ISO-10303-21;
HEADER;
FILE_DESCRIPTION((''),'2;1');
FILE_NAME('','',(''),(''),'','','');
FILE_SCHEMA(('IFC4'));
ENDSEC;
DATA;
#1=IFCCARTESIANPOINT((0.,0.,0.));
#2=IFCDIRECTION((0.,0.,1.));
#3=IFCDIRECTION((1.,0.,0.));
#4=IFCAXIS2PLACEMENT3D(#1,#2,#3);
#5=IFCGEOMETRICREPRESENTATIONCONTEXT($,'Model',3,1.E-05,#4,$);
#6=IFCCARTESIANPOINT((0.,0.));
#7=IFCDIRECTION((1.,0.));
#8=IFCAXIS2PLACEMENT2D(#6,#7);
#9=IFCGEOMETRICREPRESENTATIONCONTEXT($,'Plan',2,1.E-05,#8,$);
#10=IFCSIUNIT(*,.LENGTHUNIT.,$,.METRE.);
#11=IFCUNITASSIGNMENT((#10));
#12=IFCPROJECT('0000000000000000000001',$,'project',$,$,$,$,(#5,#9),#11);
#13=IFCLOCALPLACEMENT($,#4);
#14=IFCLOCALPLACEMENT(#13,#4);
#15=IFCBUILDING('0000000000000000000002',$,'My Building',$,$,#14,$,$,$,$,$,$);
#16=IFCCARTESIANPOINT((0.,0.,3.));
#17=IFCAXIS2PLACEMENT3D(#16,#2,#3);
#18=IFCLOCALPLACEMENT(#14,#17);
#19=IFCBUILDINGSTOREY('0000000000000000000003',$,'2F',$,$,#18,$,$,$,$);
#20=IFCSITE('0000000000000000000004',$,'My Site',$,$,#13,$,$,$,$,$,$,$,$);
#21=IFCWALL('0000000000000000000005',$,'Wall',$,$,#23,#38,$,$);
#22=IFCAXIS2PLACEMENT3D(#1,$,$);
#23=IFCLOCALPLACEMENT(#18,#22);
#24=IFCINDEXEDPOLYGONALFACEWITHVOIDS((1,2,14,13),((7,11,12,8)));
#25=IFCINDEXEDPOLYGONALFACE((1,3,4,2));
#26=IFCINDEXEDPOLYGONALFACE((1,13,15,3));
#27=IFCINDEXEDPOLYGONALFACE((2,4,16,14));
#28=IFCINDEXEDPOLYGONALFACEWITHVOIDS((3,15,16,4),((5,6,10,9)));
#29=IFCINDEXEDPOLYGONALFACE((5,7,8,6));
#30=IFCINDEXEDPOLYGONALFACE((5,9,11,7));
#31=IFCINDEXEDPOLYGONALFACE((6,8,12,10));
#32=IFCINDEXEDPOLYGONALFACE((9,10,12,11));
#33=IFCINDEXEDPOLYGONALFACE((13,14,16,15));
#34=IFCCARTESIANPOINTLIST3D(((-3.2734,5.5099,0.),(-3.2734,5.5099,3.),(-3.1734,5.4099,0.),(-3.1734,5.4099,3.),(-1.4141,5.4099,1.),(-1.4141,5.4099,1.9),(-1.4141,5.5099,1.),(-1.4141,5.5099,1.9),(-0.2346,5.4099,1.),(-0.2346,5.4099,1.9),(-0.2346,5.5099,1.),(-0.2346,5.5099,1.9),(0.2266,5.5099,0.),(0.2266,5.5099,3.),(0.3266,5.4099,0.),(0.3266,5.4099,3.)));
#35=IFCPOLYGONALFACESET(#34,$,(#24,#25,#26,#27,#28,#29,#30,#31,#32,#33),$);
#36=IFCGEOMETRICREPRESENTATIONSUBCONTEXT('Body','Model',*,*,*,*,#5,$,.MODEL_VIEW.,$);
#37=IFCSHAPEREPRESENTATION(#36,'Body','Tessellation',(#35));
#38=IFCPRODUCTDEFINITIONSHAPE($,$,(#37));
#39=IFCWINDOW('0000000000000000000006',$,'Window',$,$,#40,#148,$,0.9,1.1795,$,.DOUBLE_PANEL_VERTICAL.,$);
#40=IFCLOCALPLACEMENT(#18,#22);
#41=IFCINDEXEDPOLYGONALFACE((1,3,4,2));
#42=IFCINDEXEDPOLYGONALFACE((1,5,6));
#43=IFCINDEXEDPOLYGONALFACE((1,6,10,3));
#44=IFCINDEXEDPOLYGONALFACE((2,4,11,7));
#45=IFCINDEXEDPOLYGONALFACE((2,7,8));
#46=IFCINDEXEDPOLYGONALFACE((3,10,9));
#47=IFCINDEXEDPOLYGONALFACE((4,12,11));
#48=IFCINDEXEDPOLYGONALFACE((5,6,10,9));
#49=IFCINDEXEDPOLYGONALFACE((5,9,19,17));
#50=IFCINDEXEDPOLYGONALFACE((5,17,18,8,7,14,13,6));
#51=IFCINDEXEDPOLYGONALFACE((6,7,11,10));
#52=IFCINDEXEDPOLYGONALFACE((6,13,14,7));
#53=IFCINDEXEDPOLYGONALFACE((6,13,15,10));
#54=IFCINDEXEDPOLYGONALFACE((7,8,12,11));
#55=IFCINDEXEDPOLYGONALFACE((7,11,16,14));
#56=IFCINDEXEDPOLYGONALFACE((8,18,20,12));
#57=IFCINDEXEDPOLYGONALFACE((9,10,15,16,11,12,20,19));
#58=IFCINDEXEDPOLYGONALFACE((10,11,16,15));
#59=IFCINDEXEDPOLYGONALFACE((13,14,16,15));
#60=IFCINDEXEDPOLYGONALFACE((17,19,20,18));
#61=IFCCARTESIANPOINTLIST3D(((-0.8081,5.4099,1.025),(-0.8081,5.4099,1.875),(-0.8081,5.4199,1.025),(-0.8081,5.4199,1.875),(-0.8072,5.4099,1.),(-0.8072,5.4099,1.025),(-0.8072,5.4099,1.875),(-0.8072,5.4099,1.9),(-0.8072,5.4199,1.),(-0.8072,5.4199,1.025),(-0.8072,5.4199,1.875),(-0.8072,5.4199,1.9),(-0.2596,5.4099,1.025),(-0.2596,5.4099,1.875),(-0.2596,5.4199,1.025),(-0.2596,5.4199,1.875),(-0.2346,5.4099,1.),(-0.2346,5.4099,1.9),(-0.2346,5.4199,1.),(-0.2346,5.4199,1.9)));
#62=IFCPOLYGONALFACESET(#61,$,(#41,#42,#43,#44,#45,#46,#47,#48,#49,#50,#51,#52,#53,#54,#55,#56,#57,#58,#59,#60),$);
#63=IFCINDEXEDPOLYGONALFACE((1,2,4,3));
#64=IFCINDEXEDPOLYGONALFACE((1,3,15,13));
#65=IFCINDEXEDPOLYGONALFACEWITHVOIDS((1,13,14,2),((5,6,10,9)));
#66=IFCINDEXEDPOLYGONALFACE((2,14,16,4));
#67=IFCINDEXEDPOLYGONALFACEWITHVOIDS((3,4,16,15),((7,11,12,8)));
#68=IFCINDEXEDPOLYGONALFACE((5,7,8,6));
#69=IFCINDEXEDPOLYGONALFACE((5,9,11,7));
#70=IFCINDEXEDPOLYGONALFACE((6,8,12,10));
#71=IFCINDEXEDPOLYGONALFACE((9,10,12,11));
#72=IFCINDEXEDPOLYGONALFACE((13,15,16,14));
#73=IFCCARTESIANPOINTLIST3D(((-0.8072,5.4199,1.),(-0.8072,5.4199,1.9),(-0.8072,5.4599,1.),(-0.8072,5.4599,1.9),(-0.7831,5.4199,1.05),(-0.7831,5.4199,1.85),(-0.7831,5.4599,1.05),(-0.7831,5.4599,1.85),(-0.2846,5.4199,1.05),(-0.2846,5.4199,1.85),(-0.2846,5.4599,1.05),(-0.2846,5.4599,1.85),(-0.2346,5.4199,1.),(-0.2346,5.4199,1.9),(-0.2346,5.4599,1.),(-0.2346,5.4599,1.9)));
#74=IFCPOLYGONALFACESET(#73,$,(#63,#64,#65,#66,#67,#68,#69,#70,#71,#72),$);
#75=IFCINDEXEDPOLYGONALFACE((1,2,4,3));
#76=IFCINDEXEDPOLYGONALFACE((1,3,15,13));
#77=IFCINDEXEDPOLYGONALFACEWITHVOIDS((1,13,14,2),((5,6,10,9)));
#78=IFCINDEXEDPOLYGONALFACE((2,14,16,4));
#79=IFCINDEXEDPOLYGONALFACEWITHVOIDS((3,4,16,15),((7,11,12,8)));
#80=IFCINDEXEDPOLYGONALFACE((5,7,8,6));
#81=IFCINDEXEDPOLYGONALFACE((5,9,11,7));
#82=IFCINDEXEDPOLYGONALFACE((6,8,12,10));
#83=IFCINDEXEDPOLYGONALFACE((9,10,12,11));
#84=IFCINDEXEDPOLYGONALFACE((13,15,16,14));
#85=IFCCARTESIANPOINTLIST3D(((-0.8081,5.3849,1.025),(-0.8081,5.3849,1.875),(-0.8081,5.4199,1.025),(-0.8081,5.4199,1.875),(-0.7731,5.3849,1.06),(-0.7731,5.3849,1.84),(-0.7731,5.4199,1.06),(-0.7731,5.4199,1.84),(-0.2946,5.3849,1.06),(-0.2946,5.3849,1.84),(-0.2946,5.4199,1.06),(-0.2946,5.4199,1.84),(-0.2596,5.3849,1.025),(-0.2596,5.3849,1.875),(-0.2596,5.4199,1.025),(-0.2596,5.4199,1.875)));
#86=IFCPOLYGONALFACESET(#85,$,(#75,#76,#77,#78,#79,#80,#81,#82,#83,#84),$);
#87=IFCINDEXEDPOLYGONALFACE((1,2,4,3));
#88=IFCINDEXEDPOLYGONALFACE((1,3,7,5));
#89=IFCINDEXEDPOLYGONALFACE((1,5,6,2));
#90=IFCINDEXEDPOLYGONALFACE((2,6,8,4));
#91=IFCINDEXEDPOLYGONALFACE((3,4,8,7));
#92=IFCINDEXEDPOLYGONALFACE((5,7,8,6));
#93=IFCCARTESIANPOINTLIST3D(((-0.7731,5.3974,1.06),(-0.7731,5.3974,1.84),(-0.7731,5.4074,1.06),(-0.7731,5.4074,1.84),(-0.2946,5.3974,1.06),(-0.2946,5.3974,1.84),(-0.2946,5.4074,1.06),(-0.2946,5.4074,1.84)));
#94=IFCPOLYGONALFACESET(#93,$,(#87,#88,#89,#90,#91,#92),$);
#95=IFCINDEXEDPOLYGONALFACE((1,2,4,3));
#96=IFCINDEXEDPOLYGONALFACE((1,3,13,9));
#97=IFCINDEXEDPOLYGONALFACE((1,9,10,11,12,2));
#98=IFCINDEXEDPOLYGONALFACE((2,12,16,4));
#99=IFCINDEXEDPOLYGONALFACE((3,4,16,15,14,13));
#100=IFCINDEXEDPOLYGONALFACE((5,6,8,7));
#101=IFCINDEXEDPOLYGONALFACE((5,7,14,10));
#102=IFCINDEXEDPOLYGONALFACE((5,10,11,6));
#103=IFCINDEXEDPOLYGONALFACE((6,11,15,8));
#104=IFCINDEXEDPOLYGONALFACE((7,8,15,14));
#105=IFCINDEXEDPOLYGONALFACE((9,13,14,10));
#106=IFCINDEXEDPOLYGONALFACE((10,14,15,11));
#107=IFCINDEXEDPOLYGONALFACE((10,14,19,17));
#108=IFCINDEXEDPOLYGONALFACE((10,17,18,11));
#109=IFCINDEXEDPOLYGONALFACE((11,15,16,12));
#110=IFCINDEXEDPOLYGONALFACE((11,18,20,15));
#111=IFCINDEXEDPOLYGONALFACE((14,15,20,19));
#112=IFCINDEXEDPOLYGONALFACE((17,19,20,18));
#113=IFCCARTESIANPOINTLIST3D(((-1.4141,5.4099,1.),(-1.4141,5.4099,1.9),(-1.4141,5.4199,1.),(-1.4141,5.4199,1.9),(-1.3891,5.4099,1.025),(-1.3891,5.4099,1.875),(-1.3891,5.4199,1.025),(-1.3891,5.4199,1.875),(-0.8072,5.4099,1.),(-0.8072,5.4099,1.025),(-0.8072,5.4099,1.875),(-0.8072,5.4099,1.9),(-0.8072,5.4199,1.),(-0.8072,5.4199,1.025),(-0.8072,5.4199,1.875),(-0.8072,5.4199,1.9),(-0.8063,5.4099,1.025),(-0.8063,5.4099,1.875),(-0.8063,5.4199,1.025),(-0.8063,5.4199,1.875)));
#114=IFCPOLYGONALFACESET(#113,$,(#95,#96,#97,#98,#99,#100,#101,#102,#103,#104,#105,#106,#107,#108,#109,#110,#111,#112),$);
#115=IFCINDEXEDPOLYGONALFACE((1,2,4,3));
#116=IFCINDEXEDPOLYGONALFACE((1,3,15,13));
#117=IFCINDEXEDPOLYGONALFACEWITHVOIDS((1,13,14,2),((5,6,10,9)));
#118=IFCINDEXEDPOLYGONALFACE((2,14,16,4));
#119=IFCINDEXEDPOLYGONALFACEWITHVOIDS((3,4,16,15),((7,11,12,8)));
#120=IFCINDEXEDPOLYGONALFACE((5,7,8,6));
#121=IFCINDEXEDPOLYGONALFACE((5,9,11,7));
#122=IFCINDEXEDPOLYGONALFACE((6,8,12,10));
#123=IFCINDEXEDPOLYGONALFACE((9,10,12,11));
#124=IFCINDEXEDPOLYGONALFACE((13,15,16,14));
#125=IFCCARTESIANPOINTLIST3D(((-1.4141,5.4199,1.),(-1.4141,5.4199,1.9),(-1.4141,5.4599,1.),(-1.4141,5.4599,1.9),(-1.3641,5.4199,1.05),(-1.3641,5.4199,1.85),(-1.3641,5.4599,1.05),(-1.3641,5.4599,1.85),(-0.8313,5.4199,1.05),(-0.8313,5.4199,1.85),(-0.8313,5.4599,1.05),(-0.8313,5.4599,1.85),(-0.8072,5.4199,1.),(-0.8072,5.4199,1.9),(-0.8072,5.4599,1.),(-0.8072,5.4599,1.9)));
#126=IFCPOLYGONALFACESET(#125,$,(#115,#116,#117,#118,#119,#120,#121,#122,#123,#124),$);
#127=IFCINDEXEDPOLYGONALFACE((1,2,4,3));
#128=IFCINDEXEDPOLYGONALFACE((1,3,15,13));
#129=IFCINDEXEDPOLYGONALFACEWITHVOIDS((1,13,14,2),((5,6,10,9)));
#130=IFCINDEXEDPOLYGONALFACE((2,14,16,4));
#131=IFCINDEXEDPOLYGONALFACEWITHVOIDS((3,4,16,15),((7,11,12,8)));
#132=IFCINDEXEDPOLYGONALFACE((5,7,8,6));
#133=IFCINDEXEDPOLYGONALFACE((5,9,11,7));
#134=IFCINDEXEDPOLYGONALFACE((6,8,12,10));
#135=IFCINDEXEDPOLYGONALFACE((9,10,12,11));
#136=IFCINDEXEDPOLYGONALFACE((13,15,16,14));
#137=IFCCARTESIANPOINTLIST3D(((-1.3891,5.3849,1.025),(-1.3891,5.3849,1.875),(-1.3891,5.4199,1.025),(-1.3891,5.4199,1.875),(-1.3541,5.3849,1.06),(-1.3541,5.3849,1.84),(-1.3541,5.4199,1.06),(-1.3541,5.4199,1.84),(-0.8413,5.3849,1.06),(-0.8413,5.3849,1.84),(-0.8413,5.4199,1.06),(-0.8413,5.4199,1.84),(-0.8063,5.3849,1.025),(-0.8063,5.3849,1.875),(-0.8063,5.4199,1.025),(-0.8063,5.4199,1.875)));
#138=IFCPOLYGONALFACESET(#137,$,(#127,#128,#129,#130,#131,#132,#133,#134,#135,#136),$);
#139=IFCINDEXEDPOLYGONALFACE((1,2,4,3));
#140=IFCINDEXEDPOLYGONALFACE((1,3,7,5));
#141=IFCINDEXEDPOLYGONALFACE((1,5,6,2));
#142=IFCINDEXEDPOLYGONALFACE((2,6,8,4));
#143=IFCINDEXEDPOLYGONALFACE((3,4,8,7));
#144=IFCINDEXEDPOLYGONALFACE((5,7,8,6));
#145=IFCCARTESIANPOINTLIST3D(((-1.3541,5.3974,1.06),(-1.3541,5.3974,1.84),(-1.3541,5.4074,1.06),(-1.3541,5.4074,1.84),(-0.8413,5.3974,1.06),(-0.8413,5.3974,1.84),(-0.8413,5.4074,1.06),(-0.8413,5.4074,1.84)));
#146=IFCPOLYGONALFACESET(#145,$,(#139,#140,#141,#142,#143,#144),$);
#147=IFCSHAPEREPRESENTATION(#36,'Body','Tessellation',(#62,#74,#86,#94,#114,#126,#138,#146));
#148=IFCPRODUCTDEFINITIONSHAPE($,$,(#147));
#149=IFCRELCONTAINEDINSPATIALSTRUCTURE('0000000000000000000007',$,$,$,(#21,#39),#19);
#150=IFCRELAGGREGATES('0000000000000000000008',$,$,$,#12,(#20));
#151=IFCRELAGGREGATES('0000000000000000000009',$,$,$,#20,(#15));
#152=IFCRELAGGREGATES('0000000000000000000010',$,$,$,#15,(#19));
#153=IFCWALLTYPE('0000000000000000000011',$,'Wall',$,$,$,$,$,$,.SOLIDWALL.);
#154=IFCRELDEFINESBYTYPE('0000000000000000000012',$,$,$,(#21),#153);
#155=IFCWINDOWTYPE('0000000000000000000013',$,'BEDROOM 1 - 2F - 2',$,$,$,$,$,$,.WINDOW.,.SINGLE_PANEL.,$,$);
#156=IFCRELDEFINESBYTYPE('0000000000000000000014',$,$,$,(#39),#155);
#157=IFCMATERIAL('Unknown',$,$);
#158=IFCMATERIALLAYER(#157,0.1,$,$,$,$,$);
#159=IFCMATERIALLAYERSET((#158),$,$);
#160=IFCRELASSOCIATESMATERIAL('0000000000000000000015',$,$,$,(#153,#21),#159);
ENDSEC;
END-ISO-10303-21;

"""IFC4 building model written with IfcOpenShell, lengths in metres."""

from ifc_helpers import new_model, entity, si_unit, frame, origin_with_axes, origin_2d_with_axis, place, context, subcontext, project, spatial, line, indexed_curve, outline, extrude, shape, source, transform, mapped, material, layer, layer_set, layer_usage, type_object, type_shapes, element, fill, save


model = new_model("IFC4")

# Units and contexts
model_context = context("Model", 3, precision=1e-05, world=origin_with_axes())
plan_context = context("Plan", 2, precision=1e-05, world=origin_2d_with_axis())
body_context_1 = subcontext(model_context, "Body", "Model", "MODEL_VIEW")
body_context_2 = subcontext(plan_context, "Body", "Plan", "PLAN_VIEW")
ifc_project = project(units=[si_unit("LENGTHUNIT", "METRE")], contexts=[model_context, plan_context])

# Site, building, storey
site_placement = place(None, origin_with_axes())
site = spatial("IfcSite", under=ifc_project, at=site_placement, Name="My Site")
building_placement = place(site_placement, origin_with_axes())
building = spatial("IfcBuilding", under=site, at=building_placement, Name="My Building")
storey_placement = place(building_placement, frame((0.0, 0.0, 3.0), z_axis=(0.0, 0.0, 1.0), x_axis=(1.0, 0.0, 0.0)))
storey = spatial("IfcBuildingStorey", under=building, at=storey_placement, Name="2F")

# Shared definitions
ifc_material = material(Name="Unknown")

# Shared definitions
ifc_layer_1 = layer(ifc_material, 0.1)
ifc_layer_set_1 = layer_set([ifc_layer_1])
wall_type = type_object("IfcWallType", Name="Wall", PredefinedType="SOLIDWALL", material=ifc_layer_set_1)

# Wall, opening, window
ifc_layer_usage_1 = layer_usage(ifc_layer_set_1, "AXIS2", "POSITIVE", 0.0)
wall_1_placement = place(storey_placement, frame((0.2266, 5.5099, 0.0), z_axis=(0.0, 0.0, 1.0), x_axis=(-1.0, 0.0, 0.0)))
wall_1 = element("IfcWall", 1, at=wall_1_placement, inside=storey, type_object=wall_type, material=ifc_layer_usage_1, Name="Wall", context=body_context_1, shape_type="SweptSolid", body=[
    extrude(outline(indexed_curve([(0.0, 0.0), (-0.1, 0.1), (3.4, 0.1), (3.5, 0.0)], segments=[line(1, 2, 3, 4, 1)])), origin_with_axes(), (0.0, 0.0, 1.0), 3.0),
])
shared_shape_1 = source(origin_with_axes(), body_context_1, "Body", "SweptSolid", [
    extrude(outline(indexed_curve([(0.0, 0.0), (1.1795, 0.0), (1.1795, 0.9), (0.0, 0.9)], segments=[line(1, 2, 3, 4, 1)])), frame((0.0, -0.6, 0.0), z_axis=(0.0, -1.0, 0.0), x_axis=(1.0, 0.0, 0.0)), (0.0, 0.0, -1.0), 1.2),
])
opening_1_placement = place(wall_1_placement, frame((0.4612, 0.0, 1.0), z_axis=(0.0, 0.0, 1.0), x_axis=(1.0, 0.0, 0.0)))
opening_1 = element("IfcOpeningElement", 2, at=opening_1_placement, cuts=wall_1, PredefinedType="OPENING", context=body_context_1, shape_type="MappedRepresentation", body=[
    mapped(shared_shape_1, transform((0.0, 0.0, 0.0), x_axis=(1.0, 0.0, 0.0), y_axis=(0.0, 1.0, 0.0), z_axis=(0.0, 0.0, 1.0), scale=1.0)),
])
window_type_1 = type_object("IfcWindowType", Name="BEDROOM 1 - 2F - 2", PartitioningType="SINGLE_PANEL", PredefinedType="WINDOW")
shared_shape_2 = source(origin_with_axes(), body_context_1, "Body", "SweptSolid", [
    extrude(outline(indexed_curve([(0.0, 0.0), (0.5726, 0.0), (0.5726, 0.9), (0.0, 0.9)], segments=[line(1, 2, 3, 4, 1)]), holes=[indexed_curve([(0.025, 0.025), (0.5735, 0.025), (0.5735, 0.875), (0.025, 0.875)], segments=[line(1, 2, 3, 4, 1)])]), frame((0.0, 0.09, 0.0), z_axis=(0.0, -1.0, 0.0), x_axis=(1.0, 0.0, 0.0)), (0.0, 0.0, -1.0), 0.01),
    extrude(outline(indexed_curve([(0.0, 0.0), (0.5726, 0.0), (0.5726, 0.9), (0.0, 0.9)], segments=[line(1, 2, 3, 4, 1)]), holes=[indexed_curve([(0.05, 0.05), (0.5485, 0.05), (0.5485, 0.85), (0.05, 0.85)], segments=[line(1, 2, 3, 4, 1)])]), frame((0.0, 0.05, 0.0), z_axis=(0.0, -1.0, 0.0), x_axis=(1.0, 0.0, 0.0)), (0.0, 0.0, -1.0), 0.04),
    extrude(outline(indexed_curve([(0.0, 0.0), (0.5485, 0.0), (0.5485, 0.85), (0.0, 0.85)], segments=[line(1, 2, 3, 4, 1)]), holes=[indexed_curve([(0.035, 0.035), (0.5135, 0.035), (0.5135, 0.815), (0.035, 0.815)], segments=[line(1, 2, 3, 4, 1)])]), frame((0.025, 0.09, 0.025), z_axis=(0.0, -1.0, 0.0), x_axis=(1.0, 0.0, 0.0)), (0.0, 0.0, -1.0), 0.035),
    extrude(outline(indexed_curve([(0.035, 0.035), (0.5135, 0.035), (0.5135, 0.815), (0.035, 0.815)], segments=[line(1, 2, 3, 4, 1)])), frame((0.025, 0.1025, 0.025), z_axis=(0.0, -1.0, 0.0), x_axis=(1.0, 0.0, 0.0)), (0.0, 0.0, -1.0), 0.01),
    extrude(outline(indexed_curve([(0.0, 0.0), (0.607, 0.0), (0.607, 0.9), (0.0, 0.9)], segments=[line(1, 2, 3, 4, 1)]), holes=[indexed_curve([(-0.0009, 0.025), (0.582, 0.025), (0.582, 0.875), (-0.0009, 0.875)], segments=[line(1, 2, 3, 4, 1)])]), frame((0.5726, 0.09, 0.0), z_axis=(0.0, -1.0, 0.0), x_axis=(1.0, 0.0, 0.0)), (0.0, 0.0, -1.0), 0.01),
    extrude(outline(indexed_curve([(0.0, 0.0), (0.607, 0.0), (0.607, 0.9), (0.0, 0.9)], segments=[line(1, 2, 3, 4, 1)]), holes=[indexed_curve([(0.0241, 0.05), (0.557, 0.05), (0.557, 0.85), (0.0241, 0.85)], segments=[line(1, 2, 3, 4, 1)])]), frame((0.5726, 0.05, 0.0), z_axis=(0.0, -1.0, 0.0), x_axis=(1.0, 0.0, 0.0)), (0.0, 0.0, -1.0), 0.04),
    extrude(outline(indexed_curve([(0.0, 0.0), (0.5828, 0.0), (0.5828, 0.85), (0.0, 0.85)], segments=[line(1, 2, 3, 4, 1)]), holes=[indexed_curve([(0.035, 0.035), (0.5478, 0.035), (0.5478, 0.815), (0.035, 0.815)], segments=[line(1, 2, 3, 4, 1)])]), frame((0.5717, 0.09, 0.025), z_axis=(0.0, -1.0, 0.0), x_axis=(1.0, 0.0, 0.0)), (0.0, 0.0, -1.0), 0.035),
    extrude(outline(indexed_curve([(0.035, 0.035), (0.5478, 0.035), (0.5478, 0.815), (0.035, 0.815)], segments=[line(1, 2, 3, 4, 1)])), frame((0.5717, 0.1025, 0.025), z_axis=(0.0, -1.0, 0.0), x_axis=(1.0, 0.0, 0.0)), (0.0, 0.0, -1.0), 0.01),
])
shared_shape_3 = source(origin_with_axes(), body_context_2, "Body", "Curve2D", [
    entity("IfcIndexedPolyCurve", entity("IfcCartesianPointList2D", [[0.05, 0.05], [0.5485, 0.05]])),
    entity("IfcIndexedPolyCurve", entity("IfcCartesianPointList2D", [[0.0, 0.1], [0.025, 0.1], [0.025, 0.09], [0.05, 0.09], [0.05, 0.05], [0.0, 0.05]]), [entity("IfcLineIndex", [1, 2, 3, 4, 5, 6, 1])]),
    entity("IfcIndexedPolyCurve", entity("IfcCartesianPointList2D", [[0.5726, 0.1], [0.5735, 0.1], [0.5735, 0.09], [0.5485, 0.09], [0.5485, 0.05], [0.5726, 0.05]])),
    entity("IfcIndexedPolyCurve", entity("IfcCartesianPointList2D", [[0.025, 0.09], [0.06, 0.09], [0.06, 0.125], [0.025, 0.125]]), [entity("IfcLineIndex", [1, 2, 3, 4, 1])]),
    entity("IfcIndexedPolyCurve", entity("IfcCartesianPointList2D", [[0.5735, 0.09], [0.5385, 0.09], [0.5385, 0.125], [0.5735, 0.125]]), [entity("IfcLineIndex", [1, 2, 3, 4, 1])]),
    entity("IfcIndexedPolyCurve", entity("IfcCartesianPointList2D", [[0.06, 0.09], [0.5385, 0.09]])),
    entity("IfcIndexedPolyCurve", entity("IfcCartesianPointList2D", [[0.06, 0.125], [0.5385, 0.125]])),
    entity("IfcIndexedPolyCurve", entity("IfcCartesianPointList2D", [[0.06, 0.1075], [0.5385, 0.1075]])),
    entity("IfcIndexedPolyCurve", entity("IfcCartesianPointList2D", [[0.5967, 0.05], [1.1295, 0.05]])),
    entity("IfcIndexedPolyCurve", entity("IfcCartesianPointList2D", [[0.5726, 0.1], [0.5717, 0.1], [0.5717, 0.09], [0.5967, 0.09], [0.5967, 0.05], [0.5726, 0.05]])),
    entity("IfcIndexedPolyCurve", entity("IfcCartesianPointList2D", [[1.1795, 0.1], [1.1545, 0.1], [1.1545, 0.09], [1.1295, 0.09], [1.1295, 0.05], [1.1795, 0.05]]), [entity("IfcLineIndex", [1, 2, 3, 4, 5, 6, 1])]),
    entity("IfcIndexedPolyCurve", entity("IfcCartesianPointList2D", [[0.5717, 0.09], [0.6067, 0.09], [0.6067, 0.125], [0.5717, 0.125]]), [entity("IfcLineIndex", [1, 2, 3, 4, 1])]),
    entity("IfcIndexedPolyCurve", entity("IfcCartesianPointList2D", [[1.1545, 0.09], [1.1195, 0.09], [1.1195, 0.125], [1.1545, 0.125]]), [entity("IfcLineIndex", [1, 2, 3, 4, 1])]),
    entity("IfcIndexedPolyCurve", entity("IfcCartesianPointList2D", [[0.6067, 0.09], [1.1195, 0.09]])),
    entity("IfcIndexedPolyCurve", entity("IfcCartesianPointList2D", [[0.6067, 0.125], [1.1195, 0.125]])),
    entity("IfcIndexedPolyCurve", entity("IfcCartesianPointList2D", [[0.6067, 0.1075], [1.1195, 0.1075]])),
])
type_shapes(window_type_1, [shared_shape_2, shared_shape_3])
window_1_placement = place(opening_1_placement, frame((0.0, 0.0, 0.0), z_axis=(0.0, 0.0, 1.0), x_axis=(1.0, 0.0, 0.0)))
window_1 = element("IfcWindow", 3, at=window_1_placement, inside=storey, type_object=window_type_1, Name="Window", OverallHeight=0.9, OverallWidth=1.1795, PartitioningType="DOUBLE_PANEL_VERTICAL", shapes=[
    shape(body_context_1, "Body", "MappedRepresentation", [mapped(shared_shape_2, transform((0.0, 0.0, 0.0), x_axis=(1.0, 0.0, 0.0), y_axis=(0.0, 1.0, 0.0), z_axis=(0.0, 0.0, 1.0), scale=1.0))]),
    shape(body_context_2, "Body", "MappedRepresentation", [mapped(shared_shape_3, transform((0.0, 0.0, 0.0), x_axis=(1.0, 0.0, 0.0), y_axis=(0.0, 1.0, 0.0), z_axis=(0.0, 0.0, 1.0), scale=1.0))]),
])
fill(opening_1, window_1)

save(model, "model.ifc")
